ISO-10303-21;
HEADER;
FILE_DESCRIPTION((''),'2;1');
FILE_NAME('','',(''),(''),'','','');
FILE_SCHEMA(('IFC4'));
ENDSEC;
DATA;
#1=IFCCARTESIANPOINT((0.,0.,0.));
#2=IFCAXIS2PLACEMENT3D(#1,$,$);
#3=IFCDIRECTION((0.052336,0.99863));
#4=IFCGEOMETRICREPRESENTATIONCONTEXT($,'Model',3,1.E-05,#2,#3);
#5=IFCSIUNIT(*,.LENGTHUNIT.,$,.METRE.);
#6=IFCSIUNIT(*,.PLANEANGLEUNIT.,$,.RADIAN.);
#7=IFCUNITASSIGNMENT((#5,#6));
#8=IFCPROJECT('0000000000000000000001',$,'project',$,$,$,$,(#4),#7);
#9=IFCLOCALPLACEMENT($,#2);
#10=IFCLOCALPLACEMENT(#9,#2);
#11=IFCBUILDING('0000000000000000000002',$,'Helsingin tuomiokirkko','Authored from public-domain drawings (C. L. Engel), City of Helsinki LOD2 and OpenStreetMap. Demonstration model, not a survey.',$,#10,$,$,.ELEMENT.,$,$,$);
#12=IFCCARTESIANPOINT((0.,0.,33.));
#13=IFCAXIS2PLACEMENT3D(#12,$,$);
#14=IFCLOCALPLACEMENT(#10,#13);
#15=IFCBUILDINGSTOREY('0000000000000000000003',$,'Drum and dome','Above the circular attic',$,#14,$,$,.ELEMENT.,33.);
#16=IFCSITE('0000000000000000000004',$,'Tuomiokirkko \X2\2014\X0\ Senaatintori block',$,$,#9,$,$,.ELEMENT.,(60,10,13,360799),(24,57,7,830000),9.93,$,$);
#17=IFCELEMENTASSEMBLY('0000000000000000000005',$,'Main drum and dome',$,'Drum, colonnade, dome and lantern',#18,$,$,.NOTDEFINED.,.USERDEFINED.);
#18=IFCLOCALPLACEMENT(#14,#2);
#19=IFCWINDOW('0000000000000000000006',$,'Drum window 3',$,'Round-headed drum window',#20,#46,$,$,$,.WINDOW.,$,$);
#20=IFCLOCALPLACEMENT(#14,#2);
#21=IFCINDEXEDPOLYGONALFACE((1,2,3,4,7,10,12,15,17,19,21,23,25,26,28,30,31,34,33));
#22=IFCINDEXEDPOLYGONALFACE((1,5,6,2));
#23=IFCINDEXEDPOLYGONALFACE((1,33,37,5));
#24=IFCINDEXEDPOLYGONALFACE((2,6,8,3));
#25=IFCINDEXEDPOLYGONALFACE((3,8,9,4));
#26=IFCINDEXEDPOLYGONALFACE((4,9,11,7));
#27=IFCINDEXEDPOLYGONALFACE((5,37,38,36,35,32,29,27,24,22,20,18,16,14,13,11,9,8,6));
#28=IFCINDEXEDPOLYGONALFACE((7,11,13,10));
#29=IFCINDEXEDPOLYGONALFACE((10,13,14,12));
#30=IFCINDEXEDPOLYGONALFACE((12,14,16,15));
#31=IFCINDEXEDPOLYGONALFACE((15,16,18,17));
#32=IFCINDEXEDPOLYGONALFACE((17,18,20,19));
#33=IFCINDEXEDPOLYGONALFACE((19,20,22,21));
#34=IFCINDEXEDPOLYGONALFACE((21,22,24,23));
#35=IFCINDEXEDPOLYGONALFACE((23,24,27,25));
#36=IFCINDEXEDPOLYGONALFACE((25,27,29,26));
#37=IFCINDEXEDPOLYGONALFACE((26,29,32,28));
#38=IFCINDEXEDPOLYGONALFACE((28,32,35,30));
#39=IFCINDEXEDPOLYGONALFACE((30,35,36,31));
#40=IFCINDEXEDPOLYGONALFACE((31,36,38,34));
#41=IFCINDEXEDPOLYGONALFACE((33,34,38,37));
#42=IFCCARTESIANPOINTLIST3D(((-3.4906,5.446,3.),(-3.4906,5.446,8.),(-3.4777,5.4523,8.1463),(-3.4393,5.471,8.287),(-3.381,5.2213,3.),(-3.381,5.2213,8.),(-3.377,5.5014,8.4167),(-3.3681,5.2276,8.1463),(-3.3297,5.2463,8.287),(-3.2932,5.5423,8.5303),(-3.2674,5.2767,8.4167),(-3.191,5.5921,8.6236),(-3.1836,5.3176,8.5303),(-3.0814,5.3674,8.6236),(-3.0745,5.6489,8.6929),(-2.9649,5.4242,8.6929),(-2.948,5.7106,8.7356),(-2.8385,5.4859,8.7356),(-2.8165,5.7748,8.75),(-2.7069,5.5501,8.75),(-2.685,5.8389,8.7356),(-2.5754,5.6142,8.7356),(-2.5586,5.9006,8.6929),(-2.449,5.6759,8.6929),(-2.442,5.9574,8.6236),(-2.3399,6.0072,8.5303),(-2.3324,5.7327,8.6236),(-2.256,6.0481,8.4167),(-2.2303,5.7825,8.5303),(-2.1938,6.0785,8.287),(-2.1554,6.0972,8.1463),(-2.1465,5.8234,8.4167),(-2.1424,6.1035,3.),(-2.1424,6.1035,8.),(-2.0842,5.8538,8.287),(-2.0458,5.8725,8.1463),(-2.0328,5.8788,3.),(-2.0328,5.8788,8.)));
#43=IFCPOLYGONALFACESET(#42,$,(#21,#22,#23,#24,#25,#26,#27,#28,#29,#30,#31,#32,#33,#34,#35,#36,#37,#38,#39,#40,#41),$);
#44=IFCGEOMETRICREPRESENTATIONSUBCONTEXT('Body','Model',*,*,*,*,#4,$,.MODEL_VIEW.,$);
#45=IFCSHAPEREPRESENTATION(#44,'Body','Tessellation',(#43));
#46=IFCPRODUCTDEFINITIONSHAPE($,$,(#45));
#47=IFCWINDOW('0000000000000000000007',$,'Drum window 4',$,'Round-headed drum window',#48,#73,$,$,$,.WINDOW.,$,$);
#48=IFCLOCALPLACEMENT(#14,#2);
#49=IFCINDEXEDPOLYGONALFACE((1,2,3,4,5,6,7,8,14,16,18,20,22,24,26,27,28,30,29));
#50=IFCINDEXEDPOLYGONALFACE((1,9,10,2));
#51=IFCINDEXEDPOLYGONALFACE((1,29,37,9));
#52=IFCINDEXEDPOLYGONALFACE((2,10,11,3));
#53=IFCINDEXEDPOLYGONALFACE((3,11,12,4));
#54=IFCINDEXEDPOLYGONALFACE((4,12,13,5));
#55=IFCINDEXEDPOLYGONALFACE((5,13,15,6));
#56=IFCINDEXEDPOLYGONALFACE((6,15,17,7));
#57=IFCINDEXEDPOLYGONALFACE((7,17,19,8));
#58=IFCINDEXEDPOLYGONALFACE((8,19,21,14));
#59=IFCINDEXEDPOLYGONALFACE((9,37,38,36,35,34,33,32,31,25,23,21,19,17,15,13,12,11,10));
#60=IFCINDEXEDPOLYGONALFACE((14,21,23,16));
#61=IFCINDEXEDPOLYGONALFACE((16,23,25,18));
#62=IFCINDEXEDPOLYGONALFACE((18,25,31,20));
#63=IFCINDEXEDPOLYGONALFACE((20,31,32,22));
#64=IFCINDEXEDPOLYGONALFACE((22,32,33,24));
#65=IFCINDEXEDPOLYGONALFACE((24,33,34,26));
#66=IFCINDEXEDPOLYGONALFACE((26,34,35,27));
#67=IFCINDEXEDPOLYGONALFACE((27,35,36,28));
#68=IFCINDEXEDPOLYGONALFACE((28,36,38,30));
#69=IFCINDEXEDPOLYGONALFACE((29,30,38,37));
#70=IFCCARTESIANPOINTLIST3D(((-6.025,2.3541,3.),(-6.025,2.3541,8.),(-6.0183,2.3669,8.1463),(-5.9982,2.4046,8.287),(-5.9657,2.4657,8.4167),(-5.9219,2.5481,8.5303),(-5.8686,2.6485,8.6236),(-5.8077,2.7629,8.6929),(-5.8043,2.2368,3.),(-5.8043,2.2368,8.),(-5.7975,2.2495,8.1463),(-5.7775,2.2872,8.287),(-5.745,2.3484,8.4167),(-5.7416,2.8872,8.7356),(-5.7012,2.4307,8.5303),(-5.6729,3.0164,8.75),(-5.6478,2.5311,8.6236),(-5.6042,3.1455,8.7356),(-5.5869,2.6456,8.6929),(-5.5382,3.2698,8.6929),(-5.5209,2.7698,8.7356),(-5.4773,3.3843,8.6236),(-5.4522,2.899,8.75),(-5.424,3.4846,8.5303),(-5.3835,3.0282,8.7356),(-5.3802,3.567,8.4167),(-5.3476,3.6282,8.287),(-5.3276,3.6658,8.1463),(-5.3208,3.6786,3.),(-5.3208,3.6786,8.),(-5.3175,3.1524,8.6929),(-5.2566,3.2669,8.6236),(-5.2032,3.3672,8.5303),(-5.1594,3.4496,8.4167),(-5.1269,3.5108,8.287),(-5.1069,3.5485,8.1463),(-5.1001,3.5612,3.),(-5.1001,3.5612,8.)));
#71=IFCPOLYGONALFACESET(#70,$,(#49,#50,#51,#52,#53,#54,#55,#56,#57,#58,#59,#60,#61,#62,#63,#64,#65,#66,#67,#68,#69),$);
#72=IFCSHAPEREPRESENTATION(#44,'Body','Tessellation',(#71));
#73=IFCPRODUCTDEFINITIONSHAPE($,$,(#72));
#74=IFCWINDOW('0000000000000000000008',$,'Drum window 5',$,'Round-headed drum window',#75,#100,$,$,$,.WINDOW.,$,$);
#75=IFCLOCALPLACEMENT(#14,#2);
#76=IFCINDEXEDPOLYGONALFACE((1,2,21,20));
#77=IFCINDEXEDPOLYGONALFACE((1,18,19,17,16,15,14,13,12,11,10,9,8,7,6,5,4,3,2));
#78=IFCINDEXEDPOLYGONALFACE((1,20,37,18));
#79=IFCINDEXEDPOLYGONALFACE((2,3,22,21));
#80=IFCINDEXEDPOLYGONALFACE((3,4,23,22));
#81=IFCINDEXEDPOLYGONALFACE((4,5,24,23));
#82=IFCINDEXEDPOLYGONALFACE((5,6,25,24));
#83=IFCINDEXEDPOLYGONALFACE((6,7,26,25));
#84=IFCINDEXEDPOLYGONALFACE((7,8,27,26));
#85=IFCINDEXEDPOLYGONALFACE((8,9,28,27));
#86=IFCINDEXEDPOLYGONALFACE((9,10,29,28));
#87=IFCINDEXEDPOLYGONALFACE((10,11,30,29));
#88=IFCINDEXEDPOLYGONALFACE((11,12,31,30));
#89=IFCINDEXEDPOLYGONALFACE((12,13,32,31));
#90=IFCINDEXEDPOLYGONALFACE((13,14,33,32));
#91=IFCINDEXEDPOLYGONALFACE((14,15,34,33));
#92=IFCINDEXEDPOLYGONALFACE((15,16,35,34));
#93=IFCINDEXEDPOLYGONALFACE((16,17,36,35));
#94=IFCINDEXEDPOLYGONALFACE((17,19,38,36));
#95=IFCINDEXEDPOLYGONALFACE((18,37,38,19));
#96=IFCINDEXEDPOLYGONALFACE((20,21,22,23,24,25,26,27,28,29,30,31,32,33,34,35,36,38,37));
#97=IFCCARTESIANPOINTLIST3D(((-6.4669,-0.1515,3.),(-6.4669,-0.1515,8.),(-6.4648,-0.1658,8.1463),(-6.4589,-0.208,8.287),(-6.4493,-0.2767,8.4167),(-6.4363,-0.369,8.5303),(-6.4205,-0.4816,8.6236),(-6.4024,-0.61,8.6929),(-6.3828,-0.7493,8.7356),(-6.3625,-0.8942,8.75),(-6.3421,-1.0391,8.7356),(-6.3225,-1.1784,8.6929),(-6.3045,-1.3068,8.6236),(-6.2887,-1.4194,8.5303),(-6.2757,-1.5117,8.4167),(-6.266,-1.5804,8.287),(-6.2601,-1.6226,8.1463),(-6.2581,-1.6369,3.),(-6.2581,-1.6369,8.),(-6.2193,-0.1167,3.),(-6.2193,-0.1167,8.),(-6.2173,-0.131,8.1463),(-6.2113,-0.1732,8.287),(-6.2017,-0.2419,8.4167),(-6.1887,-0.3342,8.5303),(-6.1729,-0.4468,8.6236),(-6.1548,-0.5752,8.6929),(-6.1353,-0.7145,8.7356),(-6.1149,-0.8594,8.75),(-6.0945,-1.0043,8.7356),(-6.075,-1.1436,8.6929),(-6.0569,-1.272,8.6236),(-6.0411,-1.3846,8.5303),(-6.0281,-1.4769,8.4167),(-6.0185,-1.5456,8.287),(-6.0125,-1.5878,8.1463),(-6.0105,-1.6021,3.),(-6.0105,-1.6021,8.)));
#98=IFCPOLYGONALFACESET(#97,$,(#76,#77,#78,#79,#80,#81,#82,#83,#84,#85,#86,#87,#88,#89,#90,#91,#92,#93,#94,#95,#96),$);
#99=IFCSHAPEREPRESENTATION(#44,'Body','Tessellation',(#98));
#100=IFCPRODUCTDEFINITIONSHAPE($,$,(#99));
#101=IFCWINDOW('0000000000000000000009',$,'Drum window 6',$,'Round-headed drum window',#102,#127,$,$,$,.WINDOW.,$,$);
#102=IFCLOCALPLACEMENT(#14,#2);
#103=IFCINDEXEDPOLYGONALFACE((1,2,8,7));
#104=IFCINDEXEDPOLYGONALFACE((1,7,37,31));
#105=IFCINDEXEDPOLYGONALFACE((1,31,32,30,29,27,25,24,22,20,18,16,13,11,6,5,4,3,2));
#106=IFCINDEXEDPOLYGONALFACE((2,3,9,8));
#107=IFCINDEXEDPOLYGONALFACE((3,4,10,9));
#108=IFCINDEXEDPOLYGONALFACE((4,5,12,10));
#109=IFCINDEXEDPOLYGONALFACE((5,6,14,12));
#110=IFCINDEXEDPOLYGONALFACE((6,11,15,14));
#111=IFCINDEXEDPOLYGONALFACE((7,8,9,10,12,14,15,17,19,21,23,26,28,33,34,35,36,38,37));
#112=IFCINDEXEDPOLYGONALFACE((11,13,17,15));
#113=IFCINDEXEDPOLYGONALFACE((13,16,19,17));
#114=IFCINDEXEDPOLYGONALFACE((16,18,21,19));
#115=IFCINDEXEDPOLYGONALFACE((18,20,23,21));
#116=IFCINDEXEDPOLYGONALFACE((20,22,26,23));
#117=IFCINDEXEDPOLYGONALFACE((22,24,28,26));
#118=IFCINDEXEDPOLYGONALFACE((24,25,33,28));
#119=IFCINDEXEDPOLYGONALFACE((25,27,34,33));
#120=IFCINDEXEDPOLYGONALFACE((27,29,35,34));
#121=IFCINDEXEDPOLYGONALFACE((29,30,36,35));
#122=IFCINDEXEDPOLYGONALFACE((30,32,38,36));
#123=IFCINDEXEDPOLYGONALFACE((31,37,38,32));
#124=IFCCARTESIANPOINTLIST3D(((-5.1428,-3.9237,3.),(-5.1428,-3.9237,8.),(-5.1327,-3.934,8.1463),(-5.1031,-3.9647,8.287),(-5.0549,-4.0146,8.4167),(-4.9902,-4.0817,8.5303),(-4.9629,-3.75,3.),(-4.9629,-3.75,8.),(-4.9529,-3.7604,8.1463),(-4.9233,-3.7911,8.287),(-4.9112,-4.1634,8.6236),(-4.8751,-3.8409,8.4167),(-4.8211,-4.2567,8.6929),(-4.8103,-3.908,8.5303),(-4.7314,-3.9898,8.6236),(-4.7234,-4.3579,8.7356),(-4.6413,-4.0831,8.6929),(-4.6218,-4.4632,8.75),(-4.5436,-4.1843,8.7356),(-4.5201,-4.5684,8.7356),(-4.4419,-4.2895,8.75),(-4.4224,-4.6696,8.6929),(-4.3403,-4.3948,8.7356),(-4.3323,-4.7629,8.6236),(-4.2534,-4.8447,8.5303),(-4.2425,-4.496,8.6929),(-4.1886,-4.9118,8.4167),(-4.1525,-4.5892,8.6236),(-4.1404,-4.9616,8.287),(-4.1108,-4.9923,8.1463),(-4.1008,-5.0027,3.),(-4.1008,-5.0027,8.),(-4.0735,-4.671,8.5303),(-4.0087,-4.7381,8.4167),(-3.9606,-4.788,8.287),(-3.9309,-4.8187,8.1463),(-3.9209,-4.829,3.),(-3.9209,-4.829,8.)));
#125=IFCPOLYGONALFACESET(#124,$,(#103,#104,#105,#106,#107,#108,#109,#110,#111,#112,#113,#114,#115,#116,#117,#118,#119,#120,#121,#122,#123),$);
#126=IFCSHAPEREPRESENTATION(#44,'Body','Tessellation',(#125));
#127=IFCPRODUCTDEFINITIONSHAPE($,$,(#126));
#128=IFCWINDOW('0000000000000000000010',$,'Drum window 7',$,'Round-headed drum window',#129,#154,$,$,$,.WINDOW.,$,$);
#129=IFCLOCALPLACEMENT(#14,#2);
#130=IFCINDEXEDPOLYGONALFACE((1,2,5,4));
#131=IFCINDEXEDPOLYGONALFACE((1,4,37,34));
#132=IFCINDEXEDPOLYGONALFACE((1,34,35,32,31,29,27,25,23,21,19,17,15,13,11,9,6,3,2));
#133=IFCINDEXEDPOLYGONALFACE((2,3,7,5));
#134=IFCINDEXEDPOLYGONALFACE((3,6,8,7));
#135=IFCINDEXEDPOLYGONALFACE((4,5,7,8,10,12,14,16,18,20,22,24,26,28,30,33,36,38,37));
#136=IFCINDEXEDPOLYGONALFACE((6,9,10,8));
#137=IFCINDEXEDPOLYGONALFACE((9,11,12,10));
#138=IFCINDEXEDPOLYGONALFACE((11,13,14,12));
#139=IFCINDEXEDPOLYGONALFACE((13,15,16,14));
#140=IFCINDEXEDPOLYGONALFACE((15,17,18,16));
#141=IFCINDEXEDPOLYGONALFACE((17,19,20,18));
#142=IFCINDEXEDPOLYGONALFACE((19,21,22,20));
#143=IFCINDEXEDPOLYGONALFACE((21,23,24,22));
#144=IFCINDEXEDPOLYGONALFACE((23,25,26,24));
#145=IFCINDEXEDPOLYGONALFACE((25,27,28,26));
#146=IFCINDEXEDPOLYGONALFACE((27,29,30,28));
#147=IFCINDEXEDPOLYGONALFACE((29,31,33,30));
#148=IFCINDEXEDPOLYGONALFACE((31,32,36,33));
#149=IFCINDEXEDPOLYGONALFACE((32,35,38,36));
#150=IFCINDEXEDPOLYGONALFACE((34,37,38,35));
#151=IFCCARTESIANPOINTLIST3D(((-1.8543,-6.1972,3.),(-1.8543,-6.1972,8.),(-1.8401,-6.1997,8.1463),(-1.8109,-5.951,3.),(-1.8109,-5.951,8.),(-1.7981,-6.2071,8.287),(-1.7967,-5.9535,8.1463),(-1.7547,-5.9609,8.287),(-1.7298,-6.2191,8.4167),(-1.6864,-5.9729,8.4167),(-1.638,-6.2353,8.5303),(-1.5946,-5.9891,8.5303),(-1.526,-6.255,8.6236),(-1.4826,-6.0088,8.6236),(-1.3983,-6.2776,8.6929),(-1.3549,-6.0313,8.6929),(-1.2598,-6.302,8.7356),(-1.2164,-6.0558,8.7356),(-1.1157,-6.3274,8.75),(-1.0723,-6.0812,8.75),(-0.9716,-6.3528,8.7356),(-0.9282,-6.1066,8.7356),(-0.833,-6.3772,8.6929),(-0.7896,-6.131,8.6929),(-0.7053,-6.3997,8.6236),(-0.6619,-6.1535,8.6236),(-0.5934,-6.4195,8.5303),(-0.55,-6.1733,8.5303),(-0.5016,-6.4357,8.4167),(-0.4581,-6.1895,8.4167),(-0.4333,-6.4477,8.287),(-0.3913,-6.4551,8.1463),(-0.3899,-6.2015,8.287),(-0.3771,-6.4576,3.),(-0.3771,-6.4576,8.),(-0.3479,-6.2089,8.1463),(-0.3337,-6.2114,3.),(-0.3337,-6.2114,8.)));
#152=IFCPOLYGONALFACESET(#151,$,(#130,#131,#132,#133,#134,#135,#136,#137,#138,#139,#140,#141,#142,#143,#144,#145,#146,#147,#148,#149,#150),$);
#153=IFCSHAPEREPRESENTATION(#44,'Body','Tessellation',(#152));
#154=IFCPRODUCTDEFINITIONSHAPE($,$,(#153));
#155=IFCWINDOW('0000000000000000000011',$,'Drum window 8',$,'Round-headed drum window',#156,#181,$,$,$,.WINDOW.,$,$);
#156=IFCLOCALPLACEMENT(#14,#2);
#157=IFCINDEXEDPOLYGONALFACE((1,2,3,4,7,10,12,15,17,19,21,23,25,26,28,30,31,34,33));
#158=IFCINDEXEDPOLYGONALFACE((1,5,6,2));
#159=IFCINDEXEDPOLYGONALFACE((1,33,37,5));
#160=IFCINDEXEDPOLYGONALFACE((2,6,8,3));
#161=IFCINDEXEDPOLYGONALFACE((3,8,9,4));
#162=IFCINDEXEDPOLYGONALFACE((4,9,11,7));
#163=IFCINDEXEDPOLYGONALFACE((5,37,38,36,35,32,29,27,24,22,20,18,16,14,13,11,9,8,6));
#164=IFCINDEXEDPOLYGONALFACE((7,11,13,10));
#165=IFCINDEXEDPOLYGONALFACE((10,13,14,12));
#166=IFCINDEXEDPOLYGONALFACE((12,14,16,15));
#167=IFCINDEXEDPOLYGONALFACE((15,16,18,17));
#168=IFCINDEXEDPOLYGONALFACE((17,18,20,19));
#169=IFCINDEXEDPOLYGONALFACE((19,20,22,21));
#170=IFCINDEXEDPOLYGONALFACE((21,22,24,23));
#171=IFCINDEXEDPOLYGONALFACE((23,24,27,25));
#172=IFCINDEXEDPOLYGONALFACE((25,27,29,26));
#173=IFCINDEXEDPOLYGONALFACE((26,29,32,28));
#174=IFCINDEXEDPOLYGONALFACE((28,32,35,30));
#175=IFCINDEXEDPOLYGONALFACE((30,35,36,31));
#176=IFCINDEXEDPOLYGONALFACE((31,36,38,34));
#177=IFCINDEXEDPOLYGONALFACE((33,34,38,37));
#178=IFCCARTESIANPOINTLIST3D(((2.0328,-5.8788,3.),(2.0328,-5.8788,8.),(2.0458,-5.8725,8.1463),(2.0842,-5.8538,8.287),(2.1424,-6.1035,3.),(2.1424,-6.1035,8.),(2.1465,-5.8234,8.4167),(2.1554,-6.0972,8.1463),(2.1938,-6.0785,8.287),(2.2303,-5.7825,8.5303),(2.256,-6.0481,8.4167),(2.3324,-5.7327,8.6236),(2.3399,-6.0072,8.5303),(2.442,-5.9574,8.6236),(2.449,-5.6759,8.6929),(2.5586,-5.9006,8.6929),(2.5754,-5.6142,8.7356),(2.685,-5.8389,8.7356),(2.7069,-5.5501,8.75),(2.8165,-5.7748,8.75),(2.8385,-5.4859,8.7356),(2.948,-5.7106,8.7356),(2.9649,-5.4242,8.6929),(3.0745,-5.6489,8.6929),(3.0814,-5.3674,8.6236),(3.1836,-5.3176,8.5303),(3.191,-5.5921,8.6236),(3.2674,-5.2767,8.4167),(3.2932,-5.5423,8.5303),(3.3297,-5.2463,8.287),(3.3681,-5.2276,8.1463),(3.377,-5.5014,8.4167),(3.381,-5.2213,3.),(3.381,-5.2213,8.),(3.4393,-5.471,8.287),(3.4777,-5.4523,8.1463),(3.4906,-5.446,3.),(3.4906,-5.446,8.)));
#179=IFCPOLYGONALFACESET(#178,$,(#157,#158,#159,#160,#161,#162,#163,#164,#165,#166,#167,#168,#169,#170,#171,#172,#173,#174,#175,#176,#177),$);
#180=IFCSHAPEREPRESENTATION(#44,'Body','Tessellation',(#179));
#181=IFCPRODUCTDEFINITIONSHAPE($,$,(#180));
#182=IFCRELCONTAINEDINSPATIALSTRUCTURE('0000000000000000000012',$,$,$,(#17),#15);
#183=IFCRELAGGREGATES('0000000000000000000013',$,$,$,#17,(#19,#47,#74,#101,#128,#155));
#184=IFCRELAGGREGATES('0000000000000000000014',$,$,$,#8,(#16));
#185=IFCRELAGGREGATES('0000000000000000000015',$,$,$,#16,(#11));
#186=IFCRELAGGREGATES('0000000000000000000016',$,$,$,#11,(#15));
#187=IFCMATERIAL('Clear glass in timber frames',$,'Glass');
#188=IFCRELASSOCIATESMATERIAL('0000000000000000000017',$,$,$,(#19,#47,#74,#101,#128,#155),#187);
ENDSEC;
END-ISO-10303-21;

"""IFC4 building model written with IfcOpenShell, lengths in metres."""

from ifc_helpers import new_model, si_unit, direction, frame, origin, place, context, subcontext, project, spatial, polyline, outline, extrude, material, element, aggregate, save


model = new_model("IFC4")

# Units and contexts
model_context = context("Model", 3, precision=1e-05, world=origin(), true_north=direction((0.052336, 0.99863)))
body_context = subcontext(model_context, "Body", "Model", "MODEL_VIEW")
ifc_project = project(units=[si_unit("LENGTHUNIT", "METRE"), si_unit("PLANEANGLEUNIT", "RADIAN")], contexts=[model_context])

# Site, building, storey
site_placement = place(None, origin())
site = spatial("IfcSite", under=ifc_project, at=site_placement, Name="Tuomiokirkko — Senaatintori block", CompositionType="ELEMENT", RefLatitude=(60, 10, 13, 360799), RefLongitude=(24, 57, 7, 830000), RefElevation=9.93)
building_placement = place(site_placement, origin())
building = spatial("IfcBuilding", under=site, at=building_placement, Name="Helsingin tuomiokirkko", Description="Authored from public-domain drawings (C. L. Engel), City of Helsinki LOD2 and OpenStreetMap. Demonstration model, not a survey.", CompositionType="ELEMENT")
storey_placement = place(building_placement, frame((0.0, 0.0, 33.0)))
storey = spatial("IfcBuildingStorey", under=building, at=storey_placement, Name="Drum and dome", Description="Above the circular attic", CompositionType="ELEMENT", Elevation=33.0)

# Element assembly, windows
assembly_placement = place(building_placement, origin())
assembly = element("IfcElementAssembly", 1, at=assembly_placement, inside=storey, Name="Main drum and dome", ObjectType="Drum, colonnade, dome and lantern", AssemblyPlace="NOTDEFINED", PredefinedType="USERDEFINED")
ifc_material_1 = material(Name="Clear glass in timber frames", Category="Glass")
window_1_placement = place(building_placement, origin())
window_1 = element("IfcWindow", 2, at=window_1_placement, material=ifc_material_1, Name="Drum window 3", ObjectType="Round-headed drum window", PredefinedType="WINDOW", context=body_context, shape_type="SweptSolid", body=[
    extrude(outline(polyline([(-0.75, 0.0), (0.75, 0.0), (0.75, 5.0), (0.7356, 5.1463), (0.6929, 5.287), (0.6236, 5.4167), (0.5303, 5.5303), (0.4167, 5.6236), (0.287, 5.6929), (0.1463, 5.7356), (0.0, 5.75), (-0.1463, 5.7356), (-0.287, 5.6929), (-0.4167, 5.6236), (-0.5303, 5.5303), (-0.6236, 5.4167), (-0.6929, 5.287), (-0.7356, 5.1463), (-0.75, 5.0), (-0.75, 0.0)])), frame((-2.7069, 5.5501, 36.0), z_axis=(-0.438371, 0.898794, 0.0), x_axis=(-0.898794, -0.438371, 0.0)), (0.0, 0.0, 1.0), 0.25),
])
window_2_placement = place(building_placement, origin())
window_2 = element("IfcWindow", 3, at=window_2_placement, material=ifc_material_1, Name="Drum window 4", ObjectType="Round-headed drum window", PredefinedType="WINDOW", context=body_context, shape_type="SweptSolid", body=[
    extrude(outline(polyline([(-0.75, 0.0), (0.75, 0.0), (0.75, 5.0), (0.7356, 5.1463), (0.6929, 5.287), (0.6236, 5.4167), (0.5303, 5.5303), (0.4167, 5.6236), (0.287, 5.6929), (0.1463, 5.7356), (0.0, 5.75), (-0.1463, 5.7356), (-0.287, 5.6929), (-0.4167, 5.6236), (-0.5303, 5.5303), (-0.6236, 5.4167), (-0.6929, 5.287), (-0.7356, 5.1463), (-0.75, 5.0), (-0.75, 0.0)])), frame((-5.4522, 2.899, 36.0), z_axis=(-0.882948, 0.469472, 0.0), x_axis=(-0.469472, -0.882948, 0.0)), (0.0, 0.0, 1.0), 0.25),
])
window_3_placement = place(building_placement, origin())
window_3 = element("IfcWindow", 4, at=window_3_placement, material=ifc_material_1, Name="Drum window 5", ObjectType="Round-headed drum window", PredefinedType="WINDOW", context=body_context, shape_type="SweptSolid", body=[
    extrude(outline(polyline([(-0.75, 0.0), (0.75, 0.0), (0.75, 5.0), (0.7356, 5.1463), (0.6929, 5.287), (0.6236, 5.4167), (0.5303, 5.5303), (0.4167, 5.6236), (0.287, 5.6929), (0.1463, 5.7356), (0.0, 5.75), (-0.1463, 5.7356), (-0.287, 5.6929), (-0.4167, 5.6236), (-0.5303, 5.5303), (-0.6236, 5.4167), (-0.6929, 5.287), (-0.7356, 5.1463), (-0.75, 5.0), (-0.75, 0.0)])), frame((-6.1149, -0.8594, 36.0), z_axis=(-0.990268, -0.139173, 0.0), x_axis=(0.139173, -0.990268, 0.0)), (0.0, 0.0, 1.0), 0.25),
])
window_4_placement = place(building_placement, origin())
window_4 = element("IfcWindow", 5, at=window_4_placement, material=ifc_material_1, Name="Drum window 6", ObjectType="Round-headed drum window", PredefinedType="WINDOW", context=body_context, shape_type="SweptSolid", body=[
    extrude(outline(polyline([(-0.75, 0.0), (0.75, 0.0), (0.75, 5.0), (0.7356, 5.1463), (0.6929, 5.287), (0.6236, 5.4167), (0.5303, 5.5303), (0.4167, 5.6236), (0.287, 5.6929), (0.1463, 5.7356), (0.0, 5.75), (-0.1463, 5.7356), (-0.287, 5.6929), (-0.4167, 5.6236), (-0.5303, 5.5303), (-0.6236, 5.4167), (-0.6929, 5.287), (-0.7356, 5.1463), (-0.75, 5.0), (-0.75, 0.0)])), frame((-4.4419, -4.2895, 36.0), z_axis=(-0.71934, -0.694658, 0.0), x_axis=(0.694658, -0.71934, 0.0)), (0.0, 0.0, 1.0), 0.25),
])
window_5_placement = place(building_placement, origin())
window_5 = element("IfcWindow", 6, at=window_5_placement, material=ifc_material_1, Name="Drum window 7", ObjectType="Round-headed drum window", PredefinedType="WINDOW", context=body_context, shape_type="SweptSolid", body=[
    extrude(outline(polyline([(-0.75, 0.0), (0.75, 0.0), (0.75, 5.0), (0.7356, 5.1463), (0.6929, 5.287), (0.6236, 5.4167), (0.5303, 5.5303), (0.4167, 5.6236), (0.287, 5.6929), (0.1463, 5.7356), (0.0, 5.75), (-0.1463, 5.7356), (-0.287, 5.6929), (-0.4167, 5.6236), (-0.5303, 5.5303), (-0.6236, 5.4167), (-0.6929, 5.287), (-0.7356, 5.1463), (-0.75, 5.0), (-0.75, 0.0)])), frame((-1.0723, -6.0812, 36.0), z_axis=(-0.173648, -0.984808, 0.0), x_axis=(0.984808, -0.173648, 0.0)), (0.0, 0.0, 1.0), 0.25),
])
window_6_placement = place(building_placement, origin())
window_6 = element("IfcWindow", 7, at=window_6_placement, material=ifc_material_1, Name="Drum window 8", ObjectType="Round-headed drum window", PredefinedType="WINDOW", context=body_context, shape_type="SweptSolid", body=[
    extrude(outline(polyline([(-0.75, 0.0), (0.75, 0.0), (0.75, 5.0), (0.7356, 5.1463), (0.6929, 5.287), (0.6236, 5.4167), (0.5303, 5.5303), (0.4167, 5.6236), (0.287, 5.6929), (0.1463, 5.7356), (0.0, 5.75), (-0.1463, 5.7356), (-0.287, 5.6929), (-0.4167, 5.6236), (-0.5303, 5.5303), (-0.6236, 5.4167), (-0.6929, 5.287), (-0.7356, 5.1463), (-0.75, 5.0), (-0.75, 0.0)])), frame((2.7069, -5.5501, 36.0), z_axis=(0.438371, -0.898794, 0.0), x_axis=(0.898794, 0.438371, 0.0)), (0.0, 0.0, 1.0), 0.25),
])
aggregate(assembly, [window_1, window_2, window_3, window_4, window_5, window_6])

save(model, "model.ifc")
